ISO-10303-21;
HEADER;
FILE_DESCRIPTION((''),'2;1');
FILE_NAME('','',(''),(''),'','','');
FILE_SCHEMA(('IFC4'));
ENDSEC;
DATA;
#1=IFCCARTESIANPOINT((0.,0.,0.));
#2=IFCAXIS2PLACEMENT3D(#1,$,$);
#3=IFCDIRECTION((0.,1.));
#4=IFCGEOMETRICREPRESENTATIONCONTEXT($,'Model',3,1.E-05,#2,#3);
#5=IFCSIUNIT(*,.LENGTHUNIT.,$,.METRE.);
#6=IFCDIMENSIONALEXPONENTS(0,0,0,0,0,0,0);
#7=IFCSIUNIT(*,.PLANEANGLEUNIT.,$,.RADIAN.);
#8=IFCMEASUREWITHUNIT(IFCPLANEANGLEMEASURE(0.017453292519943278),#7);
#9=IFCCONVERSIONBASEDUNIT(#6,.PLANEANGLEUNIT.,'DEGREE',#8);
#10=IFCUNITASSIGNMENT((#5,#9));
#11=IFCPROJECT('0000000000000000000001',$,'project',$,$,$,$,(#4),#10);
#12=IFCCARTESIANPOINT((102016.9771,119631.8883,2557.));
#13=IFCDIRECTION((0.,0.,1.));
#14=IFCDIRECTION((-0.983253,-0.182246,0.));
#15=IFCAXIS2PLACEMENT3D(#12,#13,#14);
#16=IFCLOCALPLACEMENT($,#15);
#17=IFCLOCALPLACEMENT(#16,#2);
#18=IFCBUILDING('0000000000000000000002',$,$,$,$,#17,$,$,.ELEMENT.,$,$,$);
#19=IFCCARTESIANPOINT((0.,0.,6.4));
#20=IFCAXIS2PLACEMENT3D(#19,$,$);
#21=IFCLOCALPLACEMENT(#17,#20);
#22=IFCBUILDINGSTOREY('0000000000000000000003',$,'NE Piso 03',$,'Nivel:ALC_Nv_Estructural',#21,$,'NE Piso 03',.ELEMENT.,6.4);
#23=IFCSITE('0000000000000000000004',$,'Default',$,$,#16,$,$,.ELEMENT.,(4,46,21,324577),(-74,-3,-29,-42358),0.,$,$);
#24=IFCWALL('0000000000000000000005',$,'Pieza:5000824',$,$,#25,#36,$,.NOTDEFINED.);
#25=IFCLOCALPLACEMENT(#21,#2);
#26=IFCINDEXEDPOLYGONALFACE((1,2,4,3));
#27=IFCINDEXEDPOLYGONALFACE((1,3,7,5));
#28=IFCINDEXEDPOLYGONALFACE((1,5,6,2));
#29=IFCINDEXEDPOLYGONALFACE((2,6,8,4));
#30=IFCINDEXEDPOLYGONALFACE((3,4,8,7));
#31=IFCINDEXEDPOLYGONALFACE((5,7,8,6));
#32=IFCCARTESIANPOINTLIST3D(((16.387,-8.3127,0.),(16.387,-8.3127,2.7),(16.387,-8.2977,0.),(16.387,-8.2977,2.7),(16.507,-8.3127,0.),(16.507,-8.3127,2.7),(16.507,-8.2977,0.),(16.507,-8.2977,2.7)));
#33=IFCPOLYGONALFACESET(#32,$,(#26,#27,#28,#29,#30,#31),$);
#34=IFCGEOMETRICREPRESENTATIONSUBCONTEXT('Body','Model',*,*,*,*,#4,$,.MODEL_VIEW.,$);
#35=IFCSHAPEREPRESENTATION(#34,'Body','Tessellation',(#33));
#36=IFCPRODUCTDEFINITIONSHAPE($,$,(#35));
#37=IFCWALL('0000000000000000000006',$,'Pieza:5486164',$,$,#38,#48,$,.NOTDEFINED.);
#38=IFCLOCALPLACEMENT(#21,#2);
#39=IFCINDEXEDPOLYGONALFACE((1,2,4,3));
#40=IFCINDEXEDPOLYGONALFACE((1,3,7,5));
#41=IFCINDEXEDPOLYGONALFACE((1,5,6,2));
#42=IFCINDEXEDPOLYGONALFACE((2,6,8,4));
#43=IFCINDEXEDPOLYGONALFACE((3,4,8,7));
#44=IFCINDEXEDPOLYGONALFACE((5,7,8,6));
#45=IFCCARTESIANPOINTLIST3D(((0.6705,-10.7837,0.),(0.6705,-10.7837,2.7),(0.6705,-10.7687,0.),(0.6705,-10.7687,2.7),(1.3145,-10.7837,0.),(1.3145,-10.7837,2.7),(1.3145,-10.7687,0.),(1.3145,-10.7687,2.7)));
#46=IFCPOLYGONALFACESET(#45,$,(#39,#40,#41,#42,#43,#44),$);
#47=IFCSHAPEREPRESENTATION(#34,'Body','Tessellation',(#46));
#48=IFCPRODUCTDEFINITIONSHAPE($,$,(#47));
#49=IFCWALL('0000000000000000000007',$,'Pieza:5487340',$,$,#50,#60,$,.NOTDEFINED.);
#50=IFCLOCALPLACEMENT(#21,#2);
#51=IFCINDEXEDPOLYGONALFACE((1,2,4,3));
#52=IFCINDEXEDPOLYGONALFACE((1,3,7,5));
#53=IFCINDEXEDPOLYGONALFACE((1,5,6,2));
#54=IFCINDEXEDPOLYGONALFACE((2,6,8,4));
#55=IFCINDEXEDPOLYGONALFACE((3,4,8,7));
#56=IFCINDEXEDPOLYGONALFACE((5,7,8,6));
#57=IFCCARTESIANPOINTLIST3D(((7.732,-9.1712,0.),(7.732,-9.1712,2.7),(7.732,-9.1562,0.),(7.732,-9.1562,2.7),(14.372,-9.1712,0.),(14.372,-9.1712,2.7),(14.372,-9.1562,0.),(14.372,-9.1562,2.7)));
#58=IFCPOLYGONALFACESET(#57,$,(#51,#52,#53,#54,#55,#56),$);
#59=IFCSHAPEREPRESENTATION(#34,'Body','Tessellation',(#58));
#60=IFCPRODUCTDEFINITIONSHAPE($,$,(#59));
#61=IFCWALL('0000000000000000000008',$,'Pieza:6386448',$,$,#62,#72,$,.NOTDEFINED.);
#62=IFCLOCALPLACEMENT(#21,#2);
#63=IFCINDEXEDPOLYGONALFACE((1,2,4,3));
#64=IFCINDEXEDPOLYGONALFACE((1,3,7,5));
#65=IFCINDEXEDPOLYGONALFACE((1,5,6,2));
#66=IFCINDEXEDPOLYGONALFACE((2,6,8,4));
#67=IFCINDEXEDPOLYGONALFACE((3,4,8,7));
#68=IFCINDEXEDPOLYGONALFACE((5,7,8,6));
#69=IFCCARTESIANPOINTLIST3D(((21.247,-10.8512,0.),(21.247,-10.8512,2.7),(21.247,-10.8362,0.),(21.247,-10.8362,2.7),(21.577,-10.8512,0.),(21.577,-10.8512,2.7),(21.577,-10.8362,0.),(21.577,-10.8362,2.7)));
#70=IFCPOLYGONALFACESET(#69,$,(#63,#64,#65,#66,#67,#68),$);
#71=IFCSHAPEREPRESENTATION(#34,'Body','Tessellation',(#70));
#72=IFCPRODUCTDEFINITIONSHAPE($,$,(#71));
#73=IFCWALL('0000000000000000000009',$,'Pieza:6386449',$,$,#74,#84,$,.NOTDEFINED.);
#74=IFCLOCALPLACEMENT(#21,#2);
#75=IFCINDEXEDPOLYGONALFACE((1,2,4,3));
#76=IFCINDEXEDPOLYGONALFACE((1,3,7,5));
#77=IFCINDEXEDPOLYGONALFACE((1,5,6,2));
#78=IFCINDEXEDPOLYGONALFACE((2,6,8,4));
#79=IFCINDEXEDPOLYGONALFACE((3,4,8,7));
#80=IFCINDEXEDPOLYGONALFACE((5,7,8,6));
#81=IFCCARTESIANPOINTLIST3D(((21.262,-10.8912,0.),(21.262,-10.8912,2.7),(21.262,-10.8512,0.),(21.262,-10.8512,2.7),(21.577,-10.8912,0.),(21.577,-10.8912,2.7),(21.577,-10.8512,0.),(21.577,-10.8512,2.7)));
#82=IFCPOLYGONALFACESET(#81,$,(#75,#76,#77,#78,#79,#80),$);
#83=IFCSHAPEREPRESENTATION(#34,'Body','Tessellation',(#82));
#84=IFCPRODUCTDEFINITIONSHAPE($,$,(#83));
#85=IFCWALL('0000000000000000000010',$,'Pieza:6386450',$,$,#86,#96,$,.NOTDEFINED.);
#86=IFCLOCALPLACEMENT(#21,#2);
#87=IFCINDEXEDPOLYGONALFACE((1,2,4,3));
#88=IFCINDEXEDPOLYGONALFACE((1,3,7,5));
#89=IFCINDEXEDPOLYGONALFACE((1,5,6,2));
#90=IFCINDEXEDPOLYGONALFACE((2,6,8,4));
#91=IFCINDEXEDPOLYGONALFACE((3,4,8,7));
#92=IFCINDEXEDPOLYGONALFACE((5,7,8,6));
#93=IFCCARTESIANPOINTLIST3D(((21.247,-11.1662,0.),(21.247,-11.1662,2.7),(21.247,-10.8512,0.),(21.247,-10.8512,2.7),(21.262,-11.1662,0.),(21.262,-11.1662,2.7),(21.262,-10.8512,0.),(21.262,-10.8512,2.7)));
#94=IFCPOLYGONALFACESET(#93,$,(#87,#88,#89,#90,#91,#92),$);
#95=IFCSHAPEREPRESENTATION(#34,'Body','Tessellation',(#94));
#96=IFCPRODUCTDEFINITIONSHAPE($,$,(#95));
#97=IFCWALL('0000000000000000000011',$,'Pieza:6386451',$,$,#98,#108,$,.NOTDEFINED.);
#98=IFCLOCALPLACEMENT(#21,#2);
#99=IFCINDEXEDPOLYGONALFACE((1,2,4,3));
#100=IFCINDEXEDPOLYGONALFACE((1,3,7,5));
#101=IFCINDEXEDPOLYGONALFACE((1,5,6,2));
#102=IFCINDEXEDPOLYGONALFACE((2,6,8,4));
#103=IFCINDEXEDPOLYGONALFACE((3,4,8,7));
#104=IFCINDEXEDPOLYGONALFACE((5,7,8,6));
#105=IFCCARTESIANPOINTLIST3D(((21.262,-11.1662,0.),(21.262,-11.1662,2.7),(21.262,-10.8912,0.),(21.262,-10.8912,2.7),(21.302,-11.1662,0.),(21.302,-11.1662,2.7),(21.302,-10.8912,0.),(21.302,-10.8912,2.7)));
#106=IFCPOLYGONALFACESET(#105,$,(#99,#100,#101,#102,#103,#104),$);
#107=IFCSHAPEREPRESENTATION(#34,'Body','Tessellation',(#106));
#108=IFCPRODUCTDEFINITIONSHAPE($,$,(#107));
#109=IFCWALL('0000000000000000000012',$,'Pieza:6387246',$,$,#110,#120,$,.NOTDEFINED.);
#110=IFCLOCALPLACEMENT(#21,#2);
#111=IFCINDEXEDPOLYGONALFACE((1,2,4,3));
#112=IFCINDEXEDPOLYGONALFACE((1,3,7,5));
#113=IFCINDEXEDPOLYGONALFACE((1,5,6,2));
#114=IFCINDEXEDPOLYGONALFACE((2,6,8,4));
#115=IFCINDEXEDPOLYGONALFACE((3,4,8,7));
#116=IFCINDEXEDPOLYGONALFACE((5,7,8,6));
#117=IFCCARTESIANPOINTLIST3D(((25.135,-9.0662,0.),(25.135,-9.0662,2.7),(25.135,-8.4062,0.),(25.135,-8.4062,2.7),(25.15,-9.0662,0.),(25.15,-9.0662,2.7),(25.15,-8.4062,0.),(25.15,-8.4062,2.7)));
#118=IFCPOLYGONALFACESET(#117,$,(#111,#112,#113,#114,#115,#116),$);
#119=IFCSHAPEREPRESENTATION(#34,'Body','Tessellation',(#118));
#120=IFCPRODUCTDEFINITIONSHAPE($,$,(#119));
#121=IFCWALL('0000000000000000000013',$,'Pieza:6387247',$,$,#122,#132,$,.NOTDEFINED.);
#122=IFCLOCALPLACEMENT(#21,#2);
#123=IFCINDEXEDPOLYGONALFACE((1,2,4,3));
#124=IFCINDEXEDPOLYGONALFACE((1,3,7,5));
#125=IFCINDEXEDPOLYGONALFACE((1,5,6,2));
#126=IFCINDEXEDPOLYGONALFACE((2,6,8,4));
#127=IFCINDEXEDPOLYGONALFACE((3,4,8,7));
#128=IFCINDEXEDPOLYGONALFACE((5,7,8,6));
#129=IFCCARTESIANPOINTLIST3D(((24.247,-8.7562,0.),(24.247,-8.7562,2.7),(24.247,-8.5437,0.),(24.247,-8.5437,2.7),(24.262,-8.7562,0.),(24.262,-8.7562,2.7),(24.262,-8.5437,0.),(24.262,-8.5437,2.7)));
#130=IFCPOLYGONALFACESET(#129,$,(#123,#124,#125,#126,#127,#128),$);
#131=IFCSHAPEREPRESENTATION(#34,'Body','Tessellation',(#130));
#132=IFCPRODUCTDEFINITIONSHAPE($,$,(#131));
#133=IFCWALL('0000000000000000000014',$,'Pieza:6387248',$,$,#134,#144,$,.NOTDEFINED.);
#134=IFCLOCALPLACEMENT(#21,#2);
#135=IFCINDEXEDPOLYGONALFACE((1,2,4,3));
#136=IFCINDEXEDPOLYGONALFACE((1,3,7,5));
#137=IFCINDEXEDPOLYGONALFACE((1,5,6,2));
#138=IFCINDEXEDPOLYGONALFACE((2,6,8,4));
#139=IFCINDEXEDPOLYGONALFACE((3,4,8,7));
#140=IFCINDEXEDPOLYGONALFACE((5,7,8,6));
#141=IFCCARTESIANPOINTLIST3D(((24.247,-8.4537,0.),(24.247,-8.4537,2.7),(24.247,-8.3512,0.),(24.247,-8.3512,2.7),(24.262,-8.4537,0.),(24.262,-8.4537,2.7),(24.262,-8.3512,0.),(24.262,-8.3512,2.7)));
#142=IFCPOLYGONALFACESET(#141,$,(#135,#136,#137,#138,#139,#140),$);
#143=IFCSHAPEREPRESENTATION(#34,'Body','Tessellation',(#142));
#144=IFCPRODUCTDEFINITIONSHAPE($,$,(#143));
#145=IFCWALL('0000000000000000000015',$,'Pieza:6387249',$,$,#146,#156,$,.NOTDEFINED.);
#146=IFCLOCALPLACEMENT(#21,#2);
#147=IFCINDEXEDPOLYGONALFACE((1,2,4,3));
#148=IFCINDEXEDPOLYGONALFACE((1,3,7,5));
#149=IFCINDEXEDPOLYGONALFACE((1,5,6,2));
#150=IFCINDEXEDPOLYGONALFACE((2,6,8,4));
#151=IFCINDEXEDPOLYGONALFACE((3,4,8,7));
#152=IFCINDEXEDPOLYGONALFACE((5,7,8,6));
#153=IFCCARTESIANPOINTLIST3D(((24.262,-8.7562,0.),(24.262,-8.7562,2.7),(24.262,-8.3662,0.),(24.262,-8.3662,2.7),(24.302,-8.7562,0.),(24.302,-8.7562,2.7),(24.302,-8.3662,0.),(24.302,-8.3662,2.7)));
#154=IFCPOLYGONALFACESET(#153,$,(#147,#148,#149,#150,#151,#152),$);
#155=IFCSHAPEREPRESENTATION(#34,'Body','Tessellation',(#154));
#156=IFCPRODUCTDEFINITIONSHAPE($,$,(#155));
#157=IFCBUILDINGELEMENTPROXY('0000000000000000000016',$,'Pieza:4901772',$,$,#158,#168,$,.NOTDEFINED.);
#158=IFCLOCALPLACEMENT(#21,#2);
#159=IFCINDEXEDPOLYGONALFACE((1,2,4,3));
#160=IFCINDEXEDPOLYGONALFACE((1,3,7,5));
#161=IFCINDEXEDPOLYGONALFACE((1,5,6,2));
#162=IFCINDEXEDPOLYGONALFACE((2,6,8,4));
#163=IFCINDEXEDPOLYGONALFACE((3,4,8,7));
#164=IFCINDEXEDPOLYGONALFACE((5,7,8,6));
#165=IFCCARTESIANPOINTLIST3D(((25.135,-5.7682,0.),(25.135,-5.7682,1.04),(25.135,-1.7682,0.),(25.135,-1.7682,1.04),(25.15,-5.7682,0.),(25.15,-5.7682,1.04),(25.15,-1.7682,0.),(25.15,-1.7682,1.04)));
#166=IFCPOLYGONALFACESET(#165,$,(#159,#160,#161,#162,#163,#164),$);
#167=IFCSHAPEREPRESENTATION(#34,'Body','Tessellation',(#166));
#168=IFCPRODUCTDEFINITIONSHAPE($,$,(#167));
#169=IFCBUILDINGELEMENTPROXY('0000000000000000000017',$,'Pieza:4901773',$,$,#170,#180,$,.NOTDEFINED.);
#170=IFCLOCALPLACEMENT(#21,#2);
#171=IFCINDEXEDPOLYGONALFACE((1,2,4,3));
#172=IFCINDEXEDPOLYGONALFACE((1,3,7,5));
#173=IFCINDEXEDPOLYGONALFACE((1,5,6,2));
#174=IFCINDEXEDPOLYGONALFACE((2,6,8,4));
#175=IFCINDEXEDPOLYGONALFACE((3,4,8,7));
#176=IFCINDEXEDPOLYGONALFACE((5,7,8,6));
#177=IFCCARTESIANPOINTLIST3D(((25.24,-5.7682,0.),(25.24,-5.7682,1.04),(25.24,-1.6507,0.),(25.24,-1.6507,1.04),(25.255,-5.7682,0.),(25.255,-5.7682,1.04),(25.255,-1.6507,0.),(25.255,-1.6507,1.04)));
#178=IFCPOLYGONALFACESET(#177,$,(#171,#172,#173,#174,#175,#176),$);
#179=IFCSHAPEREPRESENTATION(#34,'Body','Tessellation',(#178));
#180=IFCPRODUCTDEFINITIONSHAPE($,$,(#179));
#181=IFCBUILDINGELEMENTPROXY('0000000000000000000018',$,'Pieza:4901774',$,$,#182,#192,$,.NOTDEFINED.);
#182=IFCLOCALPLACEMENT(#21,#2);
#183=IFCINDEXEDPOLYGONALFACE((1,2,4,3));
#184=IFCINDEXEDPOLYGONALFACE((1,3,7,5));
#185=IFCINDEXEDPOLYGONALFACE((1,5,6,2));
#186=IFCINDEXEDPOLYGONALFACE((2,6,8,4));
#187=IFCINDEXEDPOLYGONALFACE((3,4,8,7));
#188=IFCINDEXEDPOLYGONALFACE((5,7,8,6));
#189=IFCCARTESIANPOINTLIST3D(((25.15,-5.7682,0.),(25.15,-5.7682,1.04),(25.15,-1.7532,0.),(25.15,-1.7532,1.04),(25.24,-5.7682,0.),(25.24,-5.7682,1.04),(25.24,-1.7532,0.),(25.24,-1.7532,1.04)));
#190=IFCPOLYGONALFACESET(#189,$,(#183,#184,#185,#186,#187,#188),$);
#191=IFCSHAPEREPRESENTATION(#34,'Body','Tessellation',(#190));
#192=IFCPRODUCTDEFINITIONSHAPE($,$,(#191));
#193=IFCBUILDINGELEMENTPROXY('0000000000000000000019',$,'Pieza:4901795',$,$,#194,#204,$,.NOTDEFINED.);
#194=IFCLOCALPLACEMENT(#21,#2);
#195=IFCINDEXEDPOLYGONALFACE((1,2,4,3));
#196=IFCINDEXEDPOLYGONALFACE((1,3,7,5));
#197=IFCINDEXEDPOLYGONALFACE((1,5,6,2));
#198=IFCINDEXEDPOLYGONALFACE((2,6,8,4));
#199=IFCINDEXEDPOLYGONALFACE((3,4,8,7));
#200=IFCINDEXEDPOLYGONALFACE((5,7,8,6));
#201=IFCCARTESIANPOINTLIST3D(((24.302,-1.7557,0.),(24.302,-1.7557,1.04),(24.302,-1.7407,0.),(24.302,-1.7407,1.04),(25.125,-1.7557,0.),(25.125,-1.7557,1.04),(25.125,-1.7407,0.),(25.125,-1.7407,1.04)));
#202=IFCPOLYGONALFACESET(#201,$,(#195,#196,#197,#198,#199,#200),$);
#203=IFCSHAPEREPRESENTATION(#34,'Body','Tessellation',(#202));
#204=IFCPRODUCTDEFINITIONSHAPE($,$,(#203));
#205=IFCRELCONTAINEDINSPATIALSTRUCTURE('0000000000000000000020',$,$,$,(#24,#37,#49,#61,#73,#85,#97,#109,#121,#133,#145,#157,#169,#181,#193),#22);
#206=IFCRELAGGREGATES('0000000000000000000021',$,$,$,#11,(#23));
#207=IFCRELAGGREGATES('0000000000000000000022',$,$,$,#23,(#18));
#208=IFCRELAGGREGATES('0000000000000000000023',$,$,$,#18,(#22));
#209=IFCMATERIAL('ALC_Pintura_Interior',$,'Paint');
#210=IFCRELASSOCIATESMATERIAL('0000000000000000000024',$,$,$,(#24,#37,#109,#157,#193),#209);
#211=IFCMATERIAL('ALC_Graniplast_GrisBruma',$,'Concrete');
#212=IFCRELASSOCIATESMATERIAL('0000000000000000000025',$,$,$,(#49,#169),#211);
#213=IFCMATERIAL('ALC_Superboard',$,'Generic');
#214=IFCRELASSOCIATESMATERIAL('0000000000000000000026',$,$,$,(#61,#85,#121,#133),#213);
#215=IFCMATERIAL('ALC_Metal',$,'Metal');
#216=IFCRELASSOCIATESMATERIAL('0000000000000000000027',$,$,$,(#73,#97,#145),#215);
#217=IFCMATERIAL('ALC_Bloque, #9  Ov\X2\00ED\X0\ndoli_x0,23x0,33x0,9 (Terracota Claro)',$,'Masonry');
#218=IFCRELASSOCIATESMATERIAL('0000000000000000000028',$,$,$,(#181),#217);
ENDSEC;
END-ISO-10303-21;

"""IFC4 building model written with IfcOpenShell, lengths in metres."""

from ifc_helpers import new_model, entity, si_unit, converted_unit, direction, frame, frame_2d, origin, origin_2d_with_axis, place, context, subcontext, project, spatial, rectangle, extrude, material, element, save


model = new_model("IFC4")

# Units and contexts
model_context = context("Model", 3, precision=1e-05, world=origin(), true_north=direction((0.0, 1.0)))
body_context = subcontext(model_context, "Body", "Model", "MODEL_VIEW")
ifc_project = project(units=[si_unit("LENGTHUNIT", "METRE"), converted_unit("PLANEANGLEUNIT", "DEGREE", entity("IfcPlaneAngleMeasure", 0.017453292519943278), si_unit("PLANEANGLEUNIT", "RADIAN"), dimensions=[0, 0, 0, 0, 0, 0, 0])], contexts=[model_context])

# Site, building, storey
site_placement = place(None, frame((102016.9771, 119631.8883, 2557.0), z_axis=(0.0, 0.0, 1.0), x_axis=(-0.983253, -0.182246, 0.0)))
site = spatial("IfcSite", under=ifc_project, at=site_placement, Name="Default", CompositionType="ELEMENT", RefLatitude=(4, 46, 21, 324577), RefLongitude=(-74, -3, -29, -42358), RefElevation=0.0)
building_placement = place(site_placement, origin())
building = spatial("IfcBuilding", under=site, at=building_placement, CompositionType="ELEMENT")
storey_placement = place(building_placement, frame((0.0, 0.0, 6.4)))
storey = spatial("IfcBuildingStorey", under=building, at=storey_placement, Name="NE Piso 03", ObjectType="Nivel:ALC_Nv_Estructural", LongName="NE Piso 03", CompositionType="ELEMENT", Elevation=6.4)

# Walls
ifc_material_1 = material(Name="ALC_Pintura_Interior", Category="Paint")
wall_1_placement = place(storey_placement, origin())
element("IfcWall", 1, at=wall_1_placement, inside=storey, material=ifc_material_1, Name="Pieza:5000824", PredefinedType="NOTDEFINED", context=body_context, shape_type="SweptSolid", body=[
    extrude(rectangle(XDim=0.015, YDim=0.12, at=frame_2d((0.0, 0.0), x_axis=(1.0, 0.0))), frame((16.447, -8.3052, 0.0), z_axis=(0.0, 0.0, 1.0), x_axis=(0.0, -1.0, 0.0)), (0.0, 0.0, 1.0), 2.7),
])
ifc_material_2 = material(Name="ALC_Bloque, #9  Ovíndoli_x0,23x0,33x0,9 (Terracota Claro)", Category="Masonry")
wall_2_placement = place(storey_placement, origin())
element("IfcWall", 2, at=wall_2_placement, inside=storey, material=ifc_material_1, Name="Pieza:5486164", PredefinedType="NOTDEFINED", context=body_context, shape_type="SweptSolid", body=[
    extrude(rectangle(XDim=0.015, YDim=0.644, at=frame_2d((0.0, 0.0), x_axis=(1.0, 0.0))), frame((0.9925, -10.7762, 0.0), z_axis=(0.0, 0.0, 1.0), x_axis=(0.0, -1.0, 0.0)), (0.0, 0.0, 1.0), 2.7),
])
ifc_material_3 = material(Name="ALC_Graniplast_GrisBruma", Category="Concrete")
wall_3_placement = place(storey_placement, origin())
element("IfcWall", 3, at=wall_3_placement, inside=storey, material=ifc_material_3, Name="Pieza:5487340", PredefinedType="NOTDEFINED", context=body_context, shape_type="SweptSolid", body=[
    extrude(rectangle(XDim=0.015, YDim=6.64, at=frame_2d((0.0, 0.0), x_axis=(1.0, 0.0))), frame((11.052, -9.1637, 0.0), z_axis=(0.0, 0.0, 1.0), x_axis=(0.0, -1.0, 0.0)), (0.0, 0.0, 1.0), 2.7),
])
ifc_material_4 = material(Name="ALC_Superboard", Category="Generic")
wall_4_placement = place(storey_placement, origin())
element("IfcWall", 4, at=wall_4_placement, inside=storey, material=ifc_material_4, Name="Pieza:6386448", PredefinedType="NOTDEFINED", context=body_context, shape_type="SweptSolid", body=[
    extrude(rectangle(XDim=0.015, YDim=0.33, at=frame_2d((0.0, 0.0), x_axis=(1.0, 0.0))), frame((21.412, -10.8437, 0.0), z_axis=(0.0, 0.0, 1.0), x_axis=(0.0, -1.0, 0.0)), (0.0, 0.0, 1.0), 2.7),
])
ifc_material_5 = material(Name="ALC_Metal", Category="Metal")
wall_5_placement = place(storey_placement, origin())
element("IfcWall", 5, at=wall_5_placement, inside=storey, material=ifc_material_5, Name="Pieza:6386449", PredefinedType="NOTDEFINED", context=body_context, shape_type="SweptSolid", body=[
    extrude(rectangle(XDim=0.04, YDim=0.315, at=frame_2d((0.0, 0.0), x_axis=(1.0, 0.0))), frame((21.4195, -10.8712, 0.0), z_axis=(0.0, 0.0, 1.0), x_axis=(0.0, -1.0, 0.0)), (0.0, 0.0, 1.0), 2.7),
])
wall_6_placement = place(storey_placement, origin())
element("IfcWall", 6, at=wall_6_placement, inside=storey, material=ifc_material_4, Name="Pieza:6386450", PredefinedType="NOTDEFINED", context=body_context, shape_type="SweptSolid", body=[
    extrude(rectangle(XDim=0.315, YDim=0.015, at=origin_2d_with_axis()), frame((21.2545, -11.0087, 0.0), z_axis=(0.0, 0.0, 1.0), x_axis=(0.0, -1.0, 0.0)), (0.0, 0.0, 1.0), 2.7),
])
wall_7_placement = place(storey_placement, origin())
element("IfcWall", 7, at=wall_7_placement, inside=storey, material=ifc_material_5, Name="Pieza:6386451", PredefinedType="NOTDEFINED", context=body_context, shape_type="SweptSolid", body=[
    extrude(rectangle(XDim=0.275, YDim=0.04, at=frame_2d((0.0, 0.0), x_axis=(1.0, 0.0))), frame((21.282, -11.0287, 0.0), z_axis=(0.0, 0.0, 1.0), x_axis=(0.0, -1.0, 0.0)), (0.0, 0.0, 1.0), 2.7),
])
wall_8_placement = place(storey_placement, origin())
element("IfcWall", 8, at=wall_8_placement, inside=storey, material=ifc_material_1, Name="Pieza:6387246", PredefinedType="NOTDEFINED", context=body_context, shape_type="SweptSolid", body=[
    extrude(rectangle(XDim=0.66, YDim=0.015, at=frame_2d((0.0, 0.0), x_axis=(1.0, 0.0))), frame((25.1425, -8.7362, 0.0), z_axis=(0.0, 0.0, 1.0), x_axis=(0.0, -1.0, 0.0)), (0.0, 0.0, 1.0), 2.7),
])
wall_9_placement = place(storey_placement, origin())
element("IfcWall", 9, at=wall_9_placement, inside=storey, material=ifc_material_4, Name="Pieza:6387247", PredefinedType="NOTDEFINED", context=body_context, shape_type="SweptSolid", body=[
    extrude(rectangle(XDim=0.2125, YDim=0.015, at=frame_2d((0.0, 0.0), x_axis=(1.0, 0.0))), frame((24.2545, -8.6499, 0.0), z_axis=(0.0, 0.0, 1.0), x_axis=(0.0, -1.0, 0.0)), (0.0, 0.0, 1.0), 2.7),
])
wall_10_placement = place(storey_placement, origin())
element("IfcWall", 10, at=wall_10_placement, inside=storey, material=ifc_material_4, Name="Pieza:6387248", PredefinedType="NOTDEFINED", context=body_context, shape_type="SweptSolid", body=[
    extrude(rectangle(XDim=0.1025, YDim=0.015, at=frame_2d((0.0, 0.0), x_axis=(1.0, 0.0))), frame((24.2545, -8.4024, 0.0), z_axis=(0.0, 0.0, 1.0), x_axis=(0.0, -1.0, 0.0)), (0.0, 0.0, 1.0), 2.7),
])
wall_11_placement = place(storey_placement, origin())
element("IfcWall", 11, at=wall_11_placement, inside=storey, material=ifc_material_5, Name="Pieza:6387249", PredefinedType="NOTDEFINED", context=body_context, shape_type="SweptSolid", body=[
    extrude(rectangle(XDim=0.39, YDim=0.04, at=frame_2d((0.0, 0.0), x_axis=(1.0, 0.0))), frame((24.282, -8.5612, 0.0), z_axis=(0.0, 0.0, 1.0), x_axis=(0.0, -1.0, 0.0)), (0.0, 0.0, 1.0), 2.7),
])

# Building element proxies
proxy_1_placement = place(storey_placement, origin())
element("IfcBuildingElementProxy", 12, at=proxy_1_placement, inside=storey, material=ifc_material_1, Name="Pieza:4901772", PredefinedType="NOTDEFINED", context=body_context, shape_type="SweptSolid", body=[
    extrude(rectangle(XDim=1.04, YDim=4.0, at=frame_2d((0.0, 0.0), x_axis=(1.0, 0.0))), frame((25.135, -3.7682, 0.52), z_axis=(1.0, 0.0, 0.0), x_axis=(0.0, 0.0, -1.0)), (0.0, 0.0, 1.0), 0.015),
])
proxy_2_placement = place(storey_placement, origin())
element("IfcBuildingElementProxy", 13, at=proxy_2_placement, inside=storey, material=ifc_material_3, Name="Pieza:4901773", PredefinedType="NOTDEFINED", context=body_context, shape_type="SweptSolid", body=[
    extrude(rectangle(XDim=1.04, YDim=4.1175, at=origin_2d_with_axis()), frame((25.24, -3.7094, 0.52), z_axis=(1.0, 0.0, 0.0), x_axis=(0.0, 0.0, -1.0)), (0.0, 0.0, 1.0), 0.015),
])
proxy_3_placement = place(storey_placement, origin())
element("IfcBuildingElementProxy", 14, at=proxy_3_placement, inside=storey, material=ifc_material_2, Name="Pieza:4901774", PredefinedType="NOTDEFINED", context=body_context, shape_type="SweptSolid", body=[
    extrude(rectangle(XDim=1.04, YDim=4.015, at=frame_2d((0.0, 0.0), x_axis=(1.0, 0.0))), frame((25.15, -3.7607, 0.52), z_axis=(1.0, 0.0, 0.0), x_axis=(0.0, 0.0, -1.0)), (0.0, 0.0, 1.0), 0.09),
])
proxy_4_placement = place(storey_placement, origin())
element("IfcBuildingElementProxy", 15, at=proxy_4_placement, inside=storey, material=ifc_material_1, Name="Pieza:4901795", PredefinedType="NOTDEFINED", context=body_context, shape_type="SweptSolid", body=[
    extrude(rectangle(XDim=1.04, YDim=0.015, at=frame_2d((0.0, 0.0), x_axis=(1.0, 0.0))), frame((24.302, -1.7482, 0.52), z_axis=(1.0, 0.0, 0.0), x_axis=(0.0, 0.0, -1.0)), (0.0, 0.0, 1.0), 0.823),
])

save(model, "model.ifc")
